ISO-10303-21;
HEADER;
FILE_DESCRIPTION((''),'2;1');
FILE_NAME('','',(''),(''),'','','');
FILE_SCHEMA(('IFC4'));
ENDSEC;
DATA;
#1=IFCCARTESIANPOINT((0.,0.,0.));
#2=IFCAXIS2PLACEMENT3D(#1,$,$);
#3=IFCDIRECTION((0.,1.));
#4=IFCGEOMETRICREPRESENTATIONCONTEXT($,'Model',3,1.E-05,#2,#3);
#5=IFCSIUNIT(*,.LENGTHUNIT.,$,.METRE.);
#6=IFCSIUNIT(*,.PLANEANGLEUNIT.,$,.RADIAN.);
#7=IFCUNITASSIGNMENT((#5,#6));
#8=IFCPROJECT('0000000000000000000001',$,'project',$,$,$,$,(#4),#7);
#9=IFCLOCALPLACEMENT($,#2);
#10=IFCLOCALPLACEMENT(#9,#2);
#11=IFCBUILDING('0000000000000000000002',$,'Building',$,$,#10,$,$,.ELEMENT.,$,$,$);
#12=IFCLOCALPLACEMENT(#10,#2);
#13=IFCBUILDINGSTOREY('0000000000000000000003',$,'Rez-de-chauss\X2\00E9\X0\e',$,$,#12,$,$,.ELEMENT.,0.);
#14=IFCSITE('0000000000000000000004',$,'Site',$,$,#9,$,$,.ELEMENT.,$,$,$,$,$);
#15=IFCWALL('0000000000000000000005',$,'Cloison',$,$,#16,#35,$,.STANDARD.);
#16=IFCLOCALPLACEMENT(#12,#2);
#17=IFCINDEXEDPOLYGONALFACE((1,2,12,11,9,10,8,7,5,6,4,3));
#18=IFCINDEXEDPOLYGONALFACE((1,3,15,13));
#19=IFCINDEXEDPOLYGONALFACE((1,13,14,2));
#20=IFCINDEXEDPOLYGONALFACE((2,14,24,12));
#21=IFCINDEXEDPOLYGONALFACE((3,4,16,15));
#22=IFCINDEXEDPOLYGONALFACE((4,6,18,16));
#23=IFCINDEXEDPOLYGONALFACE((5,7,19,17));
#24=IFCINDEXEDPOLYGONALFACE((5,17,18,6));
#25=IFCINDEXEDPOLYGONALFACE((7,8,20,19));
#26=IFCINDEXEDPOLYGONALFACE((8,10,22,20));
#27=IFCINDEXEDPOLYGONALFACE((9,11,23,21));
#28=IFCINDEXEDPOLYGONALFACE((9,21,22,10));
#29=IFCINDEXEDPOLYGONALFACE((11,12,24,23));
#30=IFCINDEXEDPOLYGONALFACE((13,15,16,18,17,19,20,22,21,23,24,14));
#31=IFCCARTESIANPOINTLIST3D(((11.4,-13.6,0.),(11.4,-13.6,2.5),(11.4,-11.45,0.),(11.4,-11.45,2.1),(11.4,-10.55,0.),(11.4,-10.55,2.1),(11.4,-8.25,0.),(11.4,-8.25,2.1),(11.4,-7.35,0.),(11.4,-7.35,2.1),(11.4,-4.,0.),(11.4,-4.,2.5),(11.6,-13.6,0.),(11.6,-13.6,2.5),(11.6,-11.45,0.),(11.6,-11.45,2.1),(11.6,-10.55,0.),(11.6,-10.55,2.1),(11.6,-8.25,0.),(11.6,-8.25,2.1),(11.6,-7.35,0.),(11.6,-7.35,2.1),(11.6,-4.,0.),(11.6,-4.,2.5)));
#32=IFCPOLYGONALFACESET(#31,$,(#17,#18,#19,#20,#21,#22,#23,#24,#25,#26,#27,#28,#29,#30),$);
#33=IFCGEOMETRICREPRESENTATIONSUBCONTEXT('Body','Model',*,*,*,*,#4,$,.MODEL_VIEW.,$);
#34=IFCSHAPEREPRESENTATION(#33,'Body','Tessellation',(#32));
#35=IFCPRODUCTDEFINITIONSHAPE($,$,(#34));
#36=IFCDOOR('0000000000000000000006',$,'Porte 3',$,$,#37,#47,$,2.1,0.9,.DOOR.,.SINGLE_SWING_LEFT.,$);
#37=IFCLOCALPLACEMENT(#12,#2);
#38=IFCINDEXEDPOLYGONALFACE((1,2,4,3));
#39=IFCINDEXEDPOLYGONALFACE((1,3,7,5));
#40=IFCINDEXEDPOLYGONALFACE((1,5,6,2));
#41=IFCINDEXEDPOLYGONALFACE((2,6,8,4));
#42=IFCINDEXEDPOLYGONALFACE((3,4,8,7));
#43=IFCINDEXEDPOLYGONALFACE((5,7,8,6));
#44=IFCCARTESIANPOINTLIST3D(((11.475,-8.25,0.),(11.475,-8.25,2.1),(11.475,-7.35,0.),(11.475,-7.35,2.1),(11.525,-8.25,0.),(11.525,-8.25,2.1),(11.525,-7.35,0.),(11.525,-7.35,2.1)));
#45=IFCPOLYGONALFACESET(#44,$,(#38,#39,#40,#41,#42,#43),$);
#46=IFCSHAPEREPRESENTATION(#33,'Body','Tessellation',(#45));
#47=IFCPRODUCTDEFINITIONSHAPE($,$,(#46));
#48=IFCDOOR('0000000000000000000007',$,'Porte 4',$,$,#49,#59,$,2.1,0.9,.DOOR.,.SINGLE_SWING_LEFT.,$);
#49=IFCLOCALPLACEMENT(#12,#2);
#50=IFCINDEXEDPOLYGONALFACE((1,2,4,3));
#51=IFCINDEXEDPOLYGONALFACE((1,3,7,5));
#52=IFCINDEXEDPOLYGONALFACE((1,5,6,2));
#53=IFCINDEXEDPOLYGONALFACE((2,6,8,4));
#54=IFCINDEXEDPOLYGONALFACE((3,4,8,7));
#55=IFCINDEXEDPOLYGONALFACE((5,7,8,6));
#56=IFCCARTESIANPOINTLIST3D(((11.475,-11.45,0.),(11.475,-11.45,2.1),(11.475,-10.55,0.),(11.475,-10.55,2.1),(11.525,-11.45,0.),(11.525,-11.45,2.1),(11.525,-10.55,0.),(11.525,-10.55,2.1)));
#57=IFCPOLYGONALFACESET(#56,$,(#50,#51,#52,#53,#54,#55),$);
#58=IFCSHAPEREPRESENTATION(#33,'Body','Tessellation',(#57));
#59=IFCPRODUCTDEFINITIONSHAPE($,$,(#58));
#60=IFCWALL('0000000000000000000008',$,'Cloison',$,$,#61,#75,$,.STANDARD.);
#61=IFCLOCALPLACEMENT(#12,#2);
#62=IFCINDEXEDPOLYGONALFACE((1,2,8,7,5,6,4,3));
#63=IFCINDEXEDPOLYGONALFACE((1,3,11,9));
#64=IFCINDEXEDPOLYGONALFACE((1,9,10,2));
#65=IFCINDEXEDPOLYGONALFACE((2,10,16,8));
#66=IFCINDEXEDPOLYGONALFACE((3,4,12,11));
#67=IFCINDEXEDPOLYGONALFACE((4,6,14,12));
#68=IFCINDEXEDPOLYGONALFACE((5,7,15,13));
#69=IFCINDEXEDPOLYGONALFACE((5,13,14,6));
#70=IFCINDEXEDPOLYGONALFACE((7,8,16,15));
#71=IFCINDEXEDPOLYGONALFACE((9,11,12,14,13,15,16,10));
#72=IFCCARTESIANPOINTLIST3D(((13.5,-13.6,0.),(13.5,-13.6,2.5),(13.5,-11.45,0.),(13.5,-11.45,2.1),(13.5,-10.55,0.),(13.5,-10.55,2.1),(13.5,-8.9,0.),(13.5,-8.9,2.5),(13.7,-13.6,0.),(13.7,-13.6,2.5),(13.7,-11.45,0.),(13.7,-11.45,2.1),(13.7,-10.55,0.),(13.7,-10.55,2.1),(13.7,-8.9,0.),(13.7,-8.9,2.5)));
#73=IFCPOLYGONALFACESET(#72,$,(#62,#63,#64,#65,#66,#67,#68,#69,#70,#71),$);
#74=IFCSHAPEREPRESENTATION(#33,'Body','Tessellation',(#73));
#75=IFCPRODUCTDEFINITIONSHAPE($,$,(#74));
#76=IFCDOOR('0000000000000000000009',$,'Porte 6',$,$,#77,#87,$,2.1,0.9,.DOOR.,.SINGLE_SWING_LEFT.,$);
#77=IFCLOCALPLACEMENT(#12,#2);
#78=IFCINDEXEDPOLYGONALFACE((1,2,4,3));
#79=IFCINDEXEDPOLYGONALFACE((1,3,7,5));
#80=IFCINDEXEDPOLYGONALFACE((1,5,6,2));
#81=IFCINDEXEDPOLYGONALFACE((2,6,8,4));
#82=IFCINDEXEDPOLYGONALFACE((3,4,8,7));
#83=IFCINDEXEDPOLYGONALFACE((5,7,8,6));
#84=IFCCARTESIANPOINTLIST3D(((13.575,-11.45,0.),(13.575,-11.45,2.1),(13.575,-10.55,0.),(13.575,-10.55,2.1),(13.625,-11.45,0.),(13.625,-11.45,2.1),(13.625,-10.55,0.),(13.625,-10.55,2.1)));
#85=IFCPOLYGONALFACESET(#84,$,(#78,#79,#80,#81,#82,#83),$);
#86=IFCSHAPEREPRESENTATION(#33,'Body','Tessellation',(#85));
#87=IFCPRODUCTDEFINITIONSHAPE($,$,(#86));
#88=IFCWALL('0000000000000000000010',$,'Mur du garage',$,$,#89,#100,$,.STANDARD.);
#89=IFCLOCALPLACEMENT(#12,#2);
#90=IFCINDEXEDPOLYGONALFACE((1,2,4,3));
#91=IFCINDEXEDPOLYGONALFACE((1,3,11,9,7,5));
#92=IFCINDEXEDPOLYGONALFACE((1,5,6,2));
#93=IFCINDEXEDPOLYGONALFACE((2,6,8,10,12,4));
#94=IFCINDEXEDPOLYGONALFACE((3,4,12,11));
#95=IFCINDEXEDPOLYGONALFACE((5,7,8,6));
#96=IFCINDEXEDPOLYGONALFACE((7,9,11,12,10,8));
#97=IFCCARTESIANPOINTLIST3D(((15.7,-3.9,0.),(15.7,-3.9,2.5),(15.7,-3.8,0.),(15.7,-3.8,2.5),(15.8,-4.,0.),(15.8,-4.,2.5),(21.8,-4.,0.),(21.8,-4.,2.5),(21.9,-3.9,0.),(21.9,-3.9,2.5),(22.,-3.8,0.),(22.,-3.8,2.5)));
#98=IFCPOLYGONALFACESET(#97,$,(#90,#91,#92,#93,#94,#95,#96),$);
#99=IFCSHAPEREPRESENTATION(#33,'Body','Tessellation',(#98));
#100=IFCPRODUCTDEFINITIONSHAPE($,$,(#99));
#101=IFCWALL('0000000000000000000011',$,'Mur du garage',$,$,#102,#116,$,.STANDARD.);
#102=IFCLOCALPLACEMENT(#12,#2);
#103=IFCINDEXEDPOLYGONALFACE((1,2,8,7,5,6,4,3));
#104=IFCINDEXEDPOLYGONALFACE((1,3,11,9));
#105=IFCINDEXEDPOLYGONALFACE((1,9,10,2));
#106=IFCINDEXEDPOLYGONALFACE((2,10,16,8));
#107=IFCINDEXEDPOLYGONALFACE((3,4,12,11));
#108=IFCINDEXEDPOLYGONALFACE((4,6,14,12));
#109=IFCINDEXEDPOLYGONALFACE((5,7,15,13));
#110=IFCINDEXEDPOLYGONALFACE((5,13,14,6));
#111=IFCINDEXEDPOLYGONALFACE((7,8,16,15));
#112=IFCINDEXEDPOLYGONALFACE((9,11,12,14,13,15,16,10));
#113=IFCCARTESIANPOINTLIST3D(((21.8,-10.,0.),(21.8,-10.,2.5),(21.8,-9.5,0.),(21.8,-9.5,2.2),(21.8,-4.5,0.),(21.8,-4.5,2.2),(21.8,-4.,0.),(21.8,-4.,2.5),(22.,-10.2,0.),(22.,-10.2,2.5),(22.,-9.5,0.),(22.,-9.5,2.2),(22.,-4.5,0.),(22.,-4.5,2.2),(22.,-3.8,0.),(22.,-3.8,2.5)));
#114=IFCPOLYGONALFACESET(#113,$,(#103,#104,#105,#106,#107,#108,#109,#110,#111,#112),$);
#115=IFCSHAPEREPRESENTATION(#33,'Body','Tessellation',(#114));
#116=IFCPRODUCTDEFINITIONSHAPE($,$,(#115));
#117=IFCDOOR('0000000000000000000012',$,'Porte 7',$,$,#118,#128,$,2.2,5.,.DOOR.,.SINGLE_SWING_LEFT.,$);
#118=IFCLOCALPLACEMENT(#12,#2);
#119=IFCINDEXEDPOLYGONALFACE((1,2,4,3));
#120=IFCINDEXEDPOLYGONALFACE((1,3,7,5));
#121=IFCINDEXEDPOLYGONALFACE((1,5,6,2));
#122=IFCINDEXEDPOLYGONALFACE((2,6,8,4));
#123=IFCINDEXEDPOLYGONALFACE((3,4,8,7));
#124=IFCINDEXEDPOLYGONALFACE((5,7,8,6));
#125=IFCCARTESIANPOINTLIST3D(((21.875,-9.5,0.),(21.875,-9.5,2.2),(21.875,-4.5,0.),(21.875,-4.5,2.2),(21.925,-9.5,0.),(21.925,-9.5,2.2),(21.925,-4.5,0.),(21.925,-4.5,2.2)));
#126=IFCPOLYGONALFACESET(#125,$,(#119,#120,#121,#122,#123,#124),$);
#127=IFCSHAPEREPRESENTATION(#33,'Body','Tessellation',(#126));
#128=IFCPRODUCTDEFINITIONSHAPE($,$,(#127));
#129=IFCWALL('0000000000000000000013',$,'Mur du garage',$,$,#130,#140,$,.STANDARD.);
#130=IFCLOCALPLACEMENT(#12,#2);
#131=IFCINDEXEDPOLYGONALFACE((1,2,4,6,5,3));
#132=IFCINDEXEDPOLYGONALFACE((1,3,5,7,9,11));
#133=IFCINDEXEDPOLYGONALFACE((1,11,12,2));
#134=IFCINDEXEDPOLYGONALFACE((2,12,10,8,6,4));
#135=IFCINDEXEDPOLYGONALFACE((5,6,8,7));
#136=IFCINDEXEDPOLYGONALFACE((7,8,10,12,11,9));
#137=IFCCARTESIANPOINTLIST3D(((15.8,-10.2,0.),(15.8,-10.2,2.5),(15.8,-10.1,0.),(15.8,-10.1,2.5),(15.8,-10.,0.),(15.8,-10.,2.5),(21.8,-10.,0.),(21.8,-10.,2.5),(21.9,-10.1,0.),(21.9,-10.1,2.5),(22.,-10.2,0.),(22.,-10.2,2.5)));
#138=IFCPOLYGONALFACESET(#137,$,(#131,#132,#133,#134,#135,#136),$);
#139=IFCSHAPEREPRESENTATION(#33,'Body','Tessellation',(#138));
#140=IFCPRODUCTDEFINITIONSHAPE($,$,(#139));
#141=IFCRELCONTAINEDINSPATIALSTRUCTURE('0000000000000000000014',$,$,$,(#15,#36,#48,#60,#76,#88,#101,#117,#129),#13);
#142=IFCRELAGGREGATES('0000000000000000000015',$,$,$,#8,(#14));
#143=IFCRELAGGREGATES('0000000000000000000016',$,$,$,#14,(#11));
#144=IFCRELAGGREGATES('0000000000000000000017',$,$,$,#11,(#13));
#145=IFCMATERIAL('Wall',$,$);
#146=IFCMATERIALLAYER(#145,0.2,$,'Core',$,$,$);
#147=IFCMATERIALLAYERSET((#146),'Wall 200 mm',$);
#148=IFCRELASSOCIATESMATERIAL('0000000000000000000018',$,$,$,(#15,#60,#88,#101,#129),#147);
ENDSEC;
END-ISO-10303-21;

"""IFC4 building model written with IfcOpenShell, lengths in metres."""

from ifc_helpers import new_model, si_unit, direction, frame, origin, origin_2d, place, context, subcontext, project, spatial, polyline, rectangle, outline, extrude, material, layer, layer_set, layer_usage, element, fill, save


model = new_model("IFC4")

# Units and contexts
model_context = context("Model", 3, precision=1e-05, world=origin(), true_north=direction((0.0, 1.0)))
body_context = subcontext(model_context, "Body", "Model", "MODEL_VIEW")
ifc_project = project(units=[si_unit("LENGTHUNIT", "METRE"), si_unit("PLANEANGLEUNIT", "RADIAN")], contexts=[model_context])

# Site, building, storey
site_placement = place(None, origin())
site = spatial("IfcSite", under=ifc_project, at=site_placement, Name="Site", CompositionType="ELEMENT")
building_placement = place(site_placement, origin())
building = spatial("IfcBuilding", under=site, at=building_placement, Name="Building", CompositionType="ELEMENT")
storey_placement = place(building_placement, origin())
storey = spatial("IfcBuildingStorey", under=building, at=storey_placement, Name="Rez-de-chaussée", CompositionType="ELEMENT", Elevation=0.0)

# Shared definitions
ifc_material = material(Name="Wall")
ifc_layer = layer(ifc_material, 0.2, Name="Core")
ifc_layer_set = layer_set([ifc_layer], Name="Wall 200 mm")
ifc_layer_usage = layer_usage(ifc_layer_set, "AXIS2", "POSITIVE", -0.1)

# Wall, openings, doors
wall_1_placement = place(storey_placement, frame((11.5, -3.9, 0.0), z_axis=(0.0, 0.0, 1.0), x_axis=(0.0, -1.0, 0.0)))
wall_1 = element("IfcWall", 1, at=wall_1_placement, inside=storey, material=ifc_layer_usage, Name="Cloison", PredefinedType="STANDARD", context=body_context, shape_type="SweptSolid", body=[
    extrude(outline(polyline([(0.1, 0.0), (0.1, -0.1), (9.7, -0.1), (9.7, 0.0), (9.7, 0.1), (0.1, 0.1), (0.1, 0.0)])), origin(), (0.0, 0.0, 1.0), 2.5),
])
opening_1_placement = place(wall_1_placement, frame((3.9, 0.0, 0.0)))
opening_1 = element("IfcOpeningElement", 2, at=opening_1_placement, cuts=wall_1, PredefinedType="OPENING", context=body_context, shape_type="SweptSolid", body=[
    extrude(rectangle(XDim=0.9, YDim=0.4, at=origin_2d()), origin(), (0.0, 0.0, 1.0), 2.1),
])
opening_2_placement = place(wall_1_placement, frame((7.1, 0.0, 0.0)))
opening_2 = element("IfcOpeningElement", 3, at=opening_2_placement, cuts=wall_1, PredefinedType="OPENING", context=body_context, shape_type="SweptSolid", body=[
    extrude(rectangle(XDim=0.9, YDim=0.4, at=origin_2d()), origin(), (0.0, 0.0, 1.0), 2.1),
])
door_1_placement = place(opening_1_placement, origin())
door_1 = element("IfcDoor", 4, at=door_1_placement, inside=storey, Name="Porte 3", OperationType="SINGLE_SWING_LEFT", OverallHeight=2.1, OverallWidth=0.9, PredefinedType="DOOR", context=body_context, shape_type="SweptSolid", body=[
    extrude(rectangle(XDim=0.9, YDim=0.05, at=origin_2d()), origin(), (0.0, 0.0, 1.0), 2.1),
])
fill(opening_1, door_1)
door_2_placement = place(opening_2_placement, origin())
door_2 = element("IfcDoor", 5, at=door_2_placement, inside=storey, Name="Porte 4", OperationType="SINGLE_SWING_LEFT", OverallHeight=2.1, OverallWidth=0.9, PredefinedType="DOOR", context=body_context, shape_type="SweptSolid", body=[
    extrude(rectangle(XDim=0.9, YDim=0.05, at=origin_2d()), origin(), (0.0, 0.0, 1.0), 2.1),
])
fill(opening_2, door_2)

# Wall, opening, door
wall_2_placement = place(storey_placement, frame((13.6, -8.8, 0.0), z_axis=(0.0, 0.0, 1.0), x_axis=(0.0, -1.0, 0.0)))
wall_2 = element("IfcWall", 6, at=wall_2_placement, inside=storey, material=ifc_layer_usage, Name="Cloison", PredefinedType="STANDARD", context=body_context, shape_type="SweptSolid", body=[
    extrude(outline(polyline([(0.1, 0.0), (0.1, -0.1), (4.8, -0.1), (4.8, 0.0), (4.8, 0.1), (0.1, 0.1), (0.1, 0.0)])), origin(), (0.0, 0.0, 1.0), 2.5),
])
opening_3_placement = place(wall_2_placement, frame((2.2, 0.0, 0.0)))
opening_3 = element("IfcOpeningElement", 7, at=opening_3_placement, cuts=wall_2, PredefinedType="OPENING", context=body_context, shape_type="SweptSolid", body=[
    extrude(rectangle(XDim=0.9, YDim=0.4, at=origin_2d()), origin(), (0.0, 0.0, 1.0), 2.1),
])
door_3_placement = place(opening_3_placement, origin())
door_3 = element("IfcDoor", 8, at=door_3_placement, inside=storey, Name="Porte 6", OperationType="SINGLE_SWING_LEFT", OverallHeight=2.1, OverallWidth=0.9, PredefinedType="DOOR", context=body_context, shape_type="SweptSolid", body=[
    extrude(rectangle(XDim=0.9, YDim=0.05, at=origin_2d()), origin(), (0.0, 0.0, 1.0), 2.1),
])
fill(opening_3, door_3)

# Wall
wall_3_placement = place(storey_placement, frame((15.7, -3.9, 0.0)))
element("IfcWall", 9, at=wall_3_placement, inside=storey, material=ifc_layer_usage, Name="Mur du garage", PredefinedType="STANDARD", context=body_context, shape_type="SweptSolid", body=[
    extrude(outline(polyline([(0.0, 0.0), (0.1, -0.1), (6.1, -0.1), (6.2, 0.0), (6.3, 0.1), (0.0, 0.1), (0.0, 0.0)])), origin(), (0.0, 0.0, 1.0), 2.5),
])

# Wall, opening, door
wall_4_placement = place(storey_placement, frame((21.9, -3.9, 0.0), z_axis=(0.0, 0.0, 1.0), x_axis=(0.0, -1.0, 0.0)))
wall_4 = element("IfcWall", 10, at=wall_4_placement, inside=storey, material=ifc_layer_usage, Name="Mur du garage", PredefinedType="STANDARD", context=body_context, shape_type="SweptSolid", body=[
    extrude(outline(polyline([(0.0, 0.0), (0.1, -0.1), (6.1, -0.1), (6.2, 0.0), (6.3, 0.1), (-0.1, 0.1), (0.0, 0.0)])), origin(), (0.0, 0.0, 1.0), 2.5),
])
opening_4_placement = place(wall_4_placement, frame((3.1, 0.0, 0.0)))
opening_4 = element("IfcOpeningElement", 11, at=opening_4_placement, cuts=wall_4, PredefinedType="OPENING", context=body_context, shape_type="SweptSolid", body=[
    extrude(rectangle(XDim=5.0, YDim=0.4, at=origin_2d()), origin(), (0.0, 0.0, 1.0), 2.2),
])
door_4_placement = place(opening_4_placement, origin())
door_4 = element("IfcDoor", 12, at=door_4_placement, inside=storey, Name="Porte 7", OperationType="SINGLE_SWING_LEFT", OverallHeight=2.2, OverallWidth=5.0, PredefinedType="DOOR", context=body_context, shape_type="SweptSolid", body=[
    extrude(rectangle(XDim=5.0, YDim=0.05, at=origin_2d()), origin(), (0.0, 0.0, 1.0), 2.2),
])
fill(opening_4, door_4)

# Wall
wall_5_placement = place(storey_placement, frame((21.9, -10.1, 0.0), z_axis=(0.0, 0.0, 1.0), x_axis=(-1.0, 0.0, 0.0)))
element("IfcWall", 13, at=wall_5_placement, inside=storey, material=ifc_layer_usage, Name="Mur du garage", PredefinedType="STANDARD", context=body_context, shape_type="SweptSolid", body=[
    extrude(outline(polyline([(0.0, 0.0), (0.1, -0.1), (6.1, -0.1), (6.1, 0.0), (6.1, 0.1), (-0.1, 0.1), (0.0, 0.0)])), origin(), (0.0, 0.0, 1.0), 2.5),
])

save(model, "model.ifc")
